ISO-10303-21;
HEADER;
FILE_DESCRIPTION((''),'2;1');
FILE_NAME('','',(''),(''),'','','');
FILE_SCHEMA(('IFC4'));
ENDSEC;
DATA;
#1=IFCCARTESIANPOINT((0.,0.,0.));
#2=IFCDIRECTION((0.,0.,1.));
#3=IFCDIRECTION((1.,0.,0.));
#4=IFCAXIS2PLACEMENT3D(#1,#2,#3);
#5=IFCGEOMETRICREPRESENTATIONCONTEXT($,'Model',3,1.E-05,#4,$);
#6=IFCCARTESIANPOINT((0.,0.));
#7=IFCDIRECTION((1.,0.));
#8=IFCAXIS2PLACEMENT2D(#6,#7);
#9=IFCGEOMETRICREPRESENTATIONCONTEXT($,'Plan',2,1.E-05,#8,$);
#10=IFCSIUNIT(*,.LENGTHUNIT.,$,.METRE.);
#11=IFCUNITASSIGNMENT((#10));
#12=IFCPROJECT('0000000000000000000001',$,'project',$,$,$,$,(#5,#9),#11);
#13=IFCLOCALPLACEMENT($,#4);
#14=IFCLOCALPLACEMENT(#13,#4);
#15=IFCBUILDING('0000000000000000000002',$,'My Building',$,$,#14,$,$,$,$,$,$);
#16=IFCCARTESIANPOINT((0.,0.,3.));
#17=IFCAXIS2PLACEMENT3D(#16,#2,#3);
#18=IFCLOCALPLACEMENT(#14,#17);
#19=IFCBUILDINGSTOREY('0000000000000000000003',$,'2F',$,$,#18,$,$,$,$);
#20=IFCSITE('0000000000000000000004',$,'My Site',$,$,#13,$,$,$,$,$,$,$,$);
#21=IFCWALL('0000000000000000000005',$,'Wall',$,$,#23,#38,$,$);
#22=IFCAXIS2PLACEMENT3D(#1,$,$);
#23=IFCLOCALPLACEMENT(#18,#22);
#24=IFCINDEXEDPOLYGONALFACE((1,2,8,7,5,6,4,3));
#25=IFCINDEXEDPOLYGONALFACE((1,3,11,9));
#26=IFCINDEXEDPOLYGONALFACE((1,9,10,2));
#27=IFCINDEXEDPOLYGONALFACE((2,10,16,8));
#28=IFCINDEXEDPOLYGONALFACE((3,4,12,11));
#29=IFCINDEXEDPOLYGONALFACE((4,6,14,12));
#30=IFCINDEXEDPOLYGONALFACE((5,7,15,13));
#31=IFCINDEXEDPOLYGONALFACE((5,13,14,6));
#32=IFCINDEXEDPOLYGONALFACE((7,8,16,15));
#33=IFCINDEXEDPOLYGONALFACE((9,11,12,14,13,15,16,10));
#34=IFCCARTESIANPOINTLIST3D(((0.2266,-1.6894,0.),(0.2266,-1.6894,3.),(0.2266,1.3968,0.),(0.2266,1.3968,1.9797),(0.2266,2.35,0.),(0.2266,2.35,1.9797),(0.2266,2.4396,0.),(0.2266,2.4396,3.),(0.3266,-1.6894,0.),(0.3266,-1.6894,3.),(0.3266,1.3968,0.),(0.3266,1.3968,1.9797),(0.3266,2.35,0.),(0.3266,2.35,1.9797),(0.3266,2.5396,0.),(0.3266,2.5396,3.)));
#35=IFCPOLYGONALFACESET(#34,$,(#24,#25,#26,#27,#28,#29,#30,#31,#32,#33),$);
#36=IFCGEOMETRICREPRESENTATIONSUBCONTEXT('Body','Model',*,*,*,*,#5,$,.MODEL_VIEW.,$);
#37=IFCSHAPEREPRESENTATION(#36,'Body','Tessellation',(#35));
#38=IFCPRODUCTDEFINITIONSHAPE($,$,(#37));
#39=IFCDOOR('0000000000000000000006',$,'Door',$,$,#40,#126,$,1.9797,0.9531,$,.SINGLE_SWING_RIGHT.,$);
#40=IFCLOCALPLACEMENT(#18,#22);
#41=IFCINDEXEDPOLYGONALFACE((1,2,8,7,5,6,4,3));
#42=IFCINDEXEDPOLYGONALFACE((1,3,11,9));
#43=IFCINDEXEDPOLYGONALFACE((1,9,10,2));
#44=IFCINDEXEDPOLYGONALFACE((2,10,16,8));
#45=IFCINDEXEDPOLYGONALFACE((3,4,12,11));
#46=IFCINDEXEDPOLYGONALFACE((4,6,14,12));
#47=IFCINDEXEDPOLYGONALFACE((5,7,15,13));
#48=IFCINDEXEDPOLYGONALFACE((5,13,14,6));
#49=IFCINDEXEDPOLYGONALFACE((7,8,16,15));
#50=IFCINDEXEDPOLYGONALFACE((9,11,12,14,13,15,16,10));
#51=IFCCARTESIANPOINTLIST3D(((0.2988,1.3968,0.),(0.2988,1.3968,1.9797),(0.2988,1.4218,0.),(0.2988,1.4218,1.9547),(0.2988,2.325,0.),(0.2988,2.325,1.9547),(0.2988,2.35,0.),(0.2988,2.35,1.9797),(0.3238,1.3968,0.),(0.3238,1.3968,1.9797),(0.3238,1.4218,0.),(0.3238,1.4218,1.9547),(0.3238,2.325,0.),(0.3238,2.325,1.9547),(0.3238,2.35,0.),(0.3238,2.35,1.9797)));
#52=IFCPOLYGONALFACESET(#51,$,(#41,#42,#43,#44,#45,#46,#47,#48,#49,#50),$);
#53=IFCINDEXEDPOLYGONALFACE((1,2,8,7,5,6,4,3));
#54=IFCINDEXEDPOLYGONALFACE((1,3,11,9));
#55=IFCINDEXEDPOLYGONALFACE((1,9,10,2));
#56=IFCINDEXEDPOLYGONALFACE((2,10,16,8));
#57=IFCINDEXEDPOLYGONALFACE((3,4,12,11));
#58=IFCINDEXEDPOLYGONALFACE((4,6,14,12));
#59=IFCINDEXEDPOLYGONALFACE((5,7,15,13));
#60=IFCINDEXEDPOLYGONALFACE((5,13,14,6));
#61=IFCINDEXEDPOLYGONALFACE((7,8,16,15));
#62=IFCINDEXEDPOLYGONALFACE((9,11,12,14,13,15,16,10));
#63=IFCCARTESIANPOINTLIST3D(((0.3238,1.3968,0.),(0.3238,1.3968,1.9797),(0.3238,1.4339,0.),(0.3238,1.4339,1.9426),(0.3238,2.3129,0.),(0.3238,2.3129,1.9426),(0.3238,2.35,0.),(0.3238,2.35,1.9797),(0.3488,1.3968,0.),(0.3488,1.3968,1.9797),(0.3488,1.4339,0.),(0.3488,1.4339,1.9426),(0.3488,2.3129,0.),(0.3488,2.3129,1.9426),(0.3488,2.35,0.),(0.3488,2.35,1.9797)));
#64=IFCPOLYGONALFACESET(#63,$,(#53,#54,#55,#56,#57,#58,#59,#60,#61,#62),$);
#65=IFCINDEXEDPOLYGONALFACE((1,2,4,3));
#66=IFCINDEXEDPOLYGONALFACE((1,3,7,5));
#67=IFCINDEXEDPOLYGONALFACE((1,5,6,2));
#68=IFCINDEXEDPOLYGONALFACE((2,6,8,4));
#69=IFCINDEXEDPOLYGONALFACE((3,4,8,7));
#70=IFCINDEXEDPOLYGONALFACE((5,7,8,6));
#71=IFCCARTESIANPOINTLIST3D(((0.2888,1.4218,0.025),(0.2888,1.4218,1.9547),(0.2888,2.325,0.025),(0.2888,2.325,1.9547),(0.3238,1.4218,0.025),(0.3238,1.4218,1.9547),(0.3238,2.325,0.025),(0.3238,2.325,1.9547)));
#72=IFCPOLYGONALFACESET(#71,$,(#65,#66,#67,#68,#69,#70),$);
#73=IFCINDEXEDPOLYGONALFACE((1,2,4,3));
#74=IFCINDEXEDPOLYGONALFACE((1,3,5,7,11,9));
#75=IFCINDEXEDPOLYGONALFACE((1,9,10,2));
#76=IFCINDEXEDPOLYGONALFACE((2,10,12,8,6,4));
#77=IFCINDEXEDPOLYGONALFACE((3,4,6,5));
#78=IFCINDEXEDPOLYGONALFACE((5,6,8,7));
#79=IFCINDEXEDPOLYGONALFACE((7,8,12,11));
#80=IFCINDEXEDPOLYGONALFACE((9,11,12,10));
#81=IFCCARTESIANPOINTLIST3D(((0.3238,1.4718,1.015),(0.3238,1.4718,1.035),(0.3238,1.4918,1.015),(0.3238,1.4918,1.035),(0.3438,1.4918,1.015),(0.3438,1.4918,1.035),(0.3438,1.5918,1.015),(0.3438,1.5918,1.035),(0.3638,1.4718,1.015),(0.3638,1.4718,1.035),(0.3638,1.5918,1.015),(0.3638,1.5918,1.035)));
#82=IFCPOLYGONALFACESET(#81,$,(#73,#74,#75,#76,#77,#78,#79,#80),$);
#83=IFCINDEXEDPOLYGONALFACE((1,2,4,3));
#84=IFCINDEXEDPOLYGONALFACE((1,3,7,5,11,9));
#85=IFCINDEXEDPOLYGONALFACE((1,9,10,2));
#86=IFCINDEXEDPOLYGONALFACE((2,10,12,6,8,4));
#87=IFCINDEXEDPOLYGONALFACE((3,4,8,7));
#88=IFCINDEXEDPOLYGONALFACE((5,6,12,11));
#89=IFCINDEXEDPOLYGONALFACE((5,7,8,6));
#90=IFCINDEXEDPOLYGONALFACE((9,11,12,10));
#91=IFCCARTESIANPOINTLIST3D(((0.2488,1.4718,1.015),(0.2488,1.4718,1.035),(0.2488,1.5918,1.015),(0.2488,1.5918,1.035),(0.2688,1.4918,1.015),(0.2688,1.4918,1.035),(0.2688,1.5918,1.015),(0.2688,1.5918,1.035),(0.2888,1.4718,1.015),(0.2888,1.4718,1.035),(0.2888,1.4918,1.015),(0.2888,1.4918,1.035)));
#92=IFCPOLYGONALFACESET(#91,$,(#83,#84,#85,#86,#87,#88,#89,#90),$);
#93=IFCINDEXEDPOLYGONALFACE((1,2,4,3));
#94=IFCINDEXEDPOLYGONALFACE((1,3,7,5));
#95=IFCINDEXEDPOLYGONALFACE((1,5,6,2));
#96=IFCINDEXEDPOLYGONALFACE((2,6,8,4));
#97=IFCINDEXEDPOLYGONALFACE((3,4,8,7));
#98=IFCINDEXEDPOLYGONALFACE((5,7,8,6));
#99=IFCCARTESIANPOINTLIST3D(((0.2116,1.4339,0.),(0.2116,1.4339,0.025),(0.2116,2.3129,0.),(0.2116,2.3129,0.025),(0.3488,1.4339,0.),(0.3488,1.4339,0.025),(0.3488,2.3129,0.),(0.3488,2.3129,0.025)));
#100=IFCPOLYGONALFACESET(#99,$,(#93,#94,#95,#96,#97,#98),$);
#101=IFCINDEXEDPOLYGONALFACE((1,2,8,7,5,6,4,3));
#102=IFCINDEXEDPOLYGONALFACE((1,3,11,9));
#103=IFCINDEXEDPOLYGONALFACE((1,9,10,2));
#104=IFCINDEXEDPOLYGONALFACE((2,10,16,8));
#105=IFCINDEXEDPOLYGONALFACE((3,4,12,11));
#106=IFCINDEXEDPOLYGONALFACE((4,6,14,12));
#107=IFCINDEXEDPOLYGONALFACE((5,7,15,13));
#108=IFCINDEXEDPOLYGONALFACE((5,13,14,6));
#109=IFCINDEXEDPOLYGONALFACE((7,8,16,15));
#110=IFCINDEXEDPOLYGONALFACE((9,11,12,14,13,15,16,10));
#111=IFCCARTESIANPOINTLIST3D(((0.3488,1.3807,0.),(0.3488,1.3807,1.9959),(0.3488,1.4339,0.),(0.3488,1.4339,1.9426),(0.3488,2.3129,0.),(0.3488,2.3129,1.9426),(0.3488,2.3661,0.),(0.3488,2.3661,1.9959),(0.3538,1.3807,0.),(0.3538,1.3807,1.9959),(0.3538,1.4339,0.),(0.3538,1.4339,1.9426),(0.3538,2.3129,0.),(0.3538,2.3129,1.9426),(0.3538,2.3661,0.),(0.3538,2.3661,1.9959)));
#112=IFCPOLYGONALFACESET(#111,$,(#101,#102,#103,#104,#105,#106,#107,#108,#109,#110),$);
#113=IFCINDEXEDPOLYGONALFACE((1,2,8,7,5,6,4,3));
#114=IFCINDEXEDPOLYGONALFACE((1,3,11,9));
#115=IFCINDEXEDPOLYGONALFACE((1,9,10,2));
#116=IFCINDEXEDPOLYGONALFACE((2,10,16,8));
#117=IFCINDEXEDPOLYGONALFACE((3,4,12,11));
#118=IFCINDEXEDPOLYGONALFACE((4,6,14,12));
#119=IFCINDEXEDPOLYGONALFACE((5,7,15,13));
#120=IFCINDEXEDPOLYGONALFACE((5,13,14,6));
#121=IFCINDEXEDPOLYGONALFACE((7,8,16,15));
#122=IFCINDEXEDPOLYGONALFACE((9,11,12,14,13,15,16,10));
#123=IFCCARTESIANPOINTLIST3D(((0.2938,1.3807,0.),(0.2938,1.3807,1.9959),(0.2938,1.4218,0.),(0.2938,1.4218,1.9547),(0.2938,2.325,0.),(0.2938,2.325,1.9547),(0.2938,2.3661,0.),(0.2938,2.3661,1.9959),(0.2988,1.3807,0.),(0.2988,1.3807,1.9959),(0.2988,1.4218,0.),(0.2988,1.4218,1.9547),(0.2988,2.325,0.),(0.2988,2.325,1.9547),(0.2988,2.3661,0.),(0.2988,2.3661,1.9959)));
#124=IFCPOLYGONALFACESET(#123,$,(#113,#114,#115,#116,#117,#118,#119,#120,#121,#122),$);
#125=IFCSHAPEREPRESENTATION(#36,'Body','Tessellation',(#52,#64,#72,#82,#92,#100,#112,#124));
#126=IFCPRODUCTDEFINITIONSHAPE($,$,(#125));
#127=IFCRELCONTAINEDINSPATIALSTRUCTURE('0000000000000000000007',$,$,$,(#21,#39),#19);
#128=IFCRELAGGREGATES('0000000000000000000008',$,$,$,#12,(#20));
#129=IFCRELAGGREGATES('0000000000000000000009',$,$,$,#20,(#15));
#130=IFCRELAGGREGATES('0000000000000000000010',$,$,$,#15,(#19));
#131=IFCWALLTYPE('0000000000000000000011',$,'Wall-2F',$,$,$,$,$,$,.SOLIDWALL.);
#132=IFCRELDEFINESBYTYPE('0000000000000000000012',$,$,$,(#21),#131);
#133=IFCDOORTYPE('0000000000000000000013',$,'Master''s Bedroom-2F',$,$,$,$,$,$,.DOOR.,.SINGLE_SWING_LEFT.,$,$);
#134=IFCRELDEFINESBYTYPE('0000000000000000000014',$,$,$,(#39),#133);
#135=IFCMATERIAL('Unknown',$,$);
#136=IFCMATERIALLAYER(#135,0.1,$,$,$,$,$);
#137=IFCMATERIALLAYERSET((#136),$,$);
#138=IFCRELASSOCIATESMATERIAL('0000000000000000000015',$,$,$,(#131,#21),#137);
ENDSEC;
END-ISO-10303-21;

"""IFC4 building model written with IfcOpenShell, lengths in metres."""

from ifc_helpers import new_model, entity, si_unit, frame, origin_with_axes, origin_2d_with_axis, place, context, subcontext, project, spatial, line, indexed_curve, outline, extrude, shape, source, transform, mapped, material, layer, layer_set, layer_usage, type_object, type_shapes, element, fill, save


model = new_model("IFC4")

# Units and contexts
model_context = context("Model", 3, precision=1e-05, world=origin_with_axes())
plan_context = context("Plan", 2, precision=1e-05, world=origin_2d_with_axis())
body_context_1 = subcontext(model_context, "Body", "Model", "MODEL_VIEW")
body_context_2 = subcontext(plan_context, "Body", "Plan", "PLAN_VIEW")
ifc_project = project(units=[si_unit("LENGTHUNIT", "METRE")], contexts=[model_context, plan_context])

# Site, building, storey
site_placement = place(None, origin_with_axes())
site = spatial("IfcSite", under=ifc_project, at=site_placement, Name="My Site")
building_placement = place(site_placement, origin_with_axes())
building = spatial("IfcBuilding", under=site, at=building_placement, Name="My Building")
storey_placement = place(building_placement, frame((0.0, 0.0, 3.0), z_axis=(0.0, 0.0, 1.0), x_axis=(1.0, 0.0, 0.0)))
storey = spatial("IfcBuildingStorey", under=building, at=storey_placement, Name="2F")

# Shared definitions
ifc_material = material(Name="Unknown")

# Shared definitions
ifc_layer_1 = layer(ifc_material, 0.1)
ifc_layer_set_1 = layer_set([ifc_layer_1])
wall_type = type_object("IfcWallType", Name="Wall-2F", PredefinedType="SOLIDWALL", material=ifc_layer_set_1)

# Wall, opening, door
ifc_layer_usage_1 = layer_usage(ifc_layer_set_1, "AXIS2", "POSITIVE", 0.0)
wall_1_placement = place(storey_placement, frame((0.3266, -1.6894, 0.0), z_axis=(0.0, 0.0, 1.0), x_axis=(0.0, 1.0, 0.0)))
wall_1 = element("IfcWall", 1, at=wall_1_placement, inside=storey, type_object=wall_type, material=ifc_layer_usage_1, Name="Wall", context=body_context_1, shape_type="SweptSolid", body=[
    extrude(outline(indexed_curve([(0.0, 0.0), (0.0, 0.1), (4.129, 0.1), (4.229, 0.0)], segments=[line(1, 2, 3, 4, 1)])), origin_with_axes(), (0.0, 0.0, 1.0), 3.0),
])
shared_shape_1 = source(origin_with_axes(), body_context_1, "Body", "SweptSolid", [
    extrude(outline(indexed_curve([(0.0, 0.0), (0.9531, 0.0), (0.9531, 1.9797), (0.0, 1.9797)], segments=[line(1, 2, 3, 4, 1)])), frame((0.0, -0.6, 0.0), z_axis=(0.0, -1.0, 0.0), x_axis=(1.0, 0.0, 0.0)), (0.0, 0.0, -1.0), 1.2),
])
opening_1_placement = place(wall_1_placement, frame((3.0862, -0.0222, 0.0), z_axis=(0.0, 0.0, 1.0), x_axis=(1.0, 0.0, 0.0)))
opening_1 = element("IfcOpeningElement", 2, at=opening_1_placement, cuts=wall_1, PredefinedType="OPENING", context=body_context_1, shape_type="MappedRepresentation", body=[
    mapped(shared_shape_1, transform((0.0, 0.0, 0.0), x_axis=(1.0, 0.0, 0.0), y_axis=(0.0, 1.0, 0.0), z_axis=(0.0, 0.0, 1.0), scale=1.0)),
])
door_type_1 = type_object("IfcDoorType", Name="Master's Bedroom-2F", OperationType="SINGLE_SWING_LEFT", PredefinedType="DOOR")
shared_shape_2 = source(origin_with_axes(), body_context_1, "Body", "SweptSolid", [
    extrude(outline(indexed_curve([(0.0, 0.0), (0.0, 1.9797), (0.9531, 1.9797), (0.9531, 0.0), (0.9281, 0.0), (0.9281, 1.9547), (0.025, 1.9547), (0.025, 0.0)], segments=[line(1, 2, 3, 4, 5, 6, 7, 8, 1)])), frame((0.0, 0.025, 0.0), z_axis=(0.0, -1.0, 0.0), x_axis=(1.0, 0.0, 0.0)), (0.0, 0.0, -1.0), 0.025),
    extrude(outline(indexed_curve([(0.0, 0.0), (0.0, 1.9797), (0.9531, 1.9797), (0.9531, 0.0), (0.9161, 0.0), (0.9161, 1.9426), (0.0371, 1.9426), (0.0371, 0.0)], segments=[line(1, 2, 3, 4, 5, 6, 7, 8, 1)])), frame((0.0, 0.0, 0.0), z_axis=(0.0, -1.0, 0.0), x_axis=(1.0, 0.0, 0.0)), (0.0, 0.0, -1.0), 0.025),
    extrude(outline(indexed_curve([(0.0, 0.0), (0.9031, 0.0), (0.9031, 0.035), (0.0, 0.035)], segments=[line(1, 2, 3, 4, 1)])), frame((0.025, 0.025, 0.025), z_axis=(0.0, 0.0, 1.0), x_axis=(1.0, 0.0, 0.0)), (0.0, 0.0, 1.0), 1.9297),
    extrude(outline(indexed_curve([(0.0, 0.0), (0.0, -0.04), (0.12, -0.04), (0.12, -0.02), (0.02, -0.02), (0.02, 0.0)], segments=[line(1, 2, 3, 4, 5, 6, 1)])), frame((0.075, 0.025, 1.015), z_axis=(0.0, 0.0, 1.0), x_axis=(1.0, 0.0, 0.0)), (0.0, 0.0, 1.0), 0.02),
    extrude(outline(indexed_curve([(0.0, 0.0), (0.0, 0.04), (0.12, 0.04), (0.12, 0.02), (0.02, 0.02), (0.02, 0.0)], segments=[line(1, 2, 3, 4, 5, 6, 1)])), frame((0.075, 0.06, 1.015), z_axis=(0.0, 0.0, 1.0), x_axis=(1.0, 0.0, 0.0)), (0.0, 0.0, 1.0), 0.02),
    extrude(outline(indexed_curve([(0.0, 0.0), (0.879, 0.0), (0.879, 0.1372), (0.0, 0.1372)], segments=[line(1, 2, 3, 4, 1)])), frame((0.0371, 0.0, 0.0), z_axis=(0.0, 0.0, 1.0), x_axis=(1.0, 0.0, 0.0)), (0.0, 0.0, 1.0), 0.025),
    extrude(outline(indexed_curve([(0.0, 0.0), (0.0, 1.9959), (0.9855, 1.9959), (0.9855, 0.0), (0.9322, 0.0), (0.9322, 1.9426), (0.0532, 1.9426), (0.0532, 0.0)], segments=[line(1, 2, 3, 4, 5, 6, 7, 8, 1)])), frame((-0.0162, -0.005, 0.0), z_axis=(0.0, -1.0, 0.0), x_axis=(1.0, 0.0, 0.0)), (0.0, 0.0, -1.0), 0.005),
    extrude(outline(indexed_curve([(0.0, 0.0), (0.0, 1.9959), (0.9855, 1.9959), (0.9855, 0.0), (0.9443, 0.0), (0.9443, 1.9547), (0.0412, 1.9547), (0.0412, 0.0)], segments=[line(1, 2, 3, 4, 5, 6, 7, 8, 1)])), frame((-0.0162, 0.05, 0.0), z_axis=(0.0, -1.0, 0.0), x_axis=(1.0, 0.0, 0.0)), (0.0, 0.0, -1.0), 0.005),
])
shared_shape_3 = source(origin_with_axes(), body_context_2, "Body", "Curve2D", [
    entity("IfcIndexedPolyCurve", entity("IfcCartesianPointList2D", [[0.0, 0.0], [0.0, 0.05], [0.025, 0.05], [0.025, 0.025], [0.0371, 0.025], [0.0371, 0.0]]), [entity("IfcLineIndex", [1, 2, 3, 4, 5, 6, 1])]),
    entity("IfcIndexedPolyCurve", entity("IfcCartesianPointList2D", [[0.9531, 0.0], [0.9531, 0.05], [0.9281, 0.05], [0.9281, 0.025], [0.9161, 0.025], [0.9161, 0.0]]), [entity("IfcLineIndex", [1, 2, 3, 4, 5, 6, 1])]),
    entity("IfcTrimmedCurve", entity("IfcEllipse", entity("IfcAxis2Placement2D", entity("IfcCartesianPoint", [0.8931, 0.05]), entity("IfcDirection", [1.0, 0.0])), 0.8681, 0.9031), [entity("IfcCartesianPoint", [0.8931, 0.9531])], [entity("IfcCartesianPoint", [0.025, 0.05])], True, "CARTESIAN"),
    entity("IfcIndexedPolyCurve", entity("IfcCartesianPointList2D", [[0.9281, 0.05], [0.8931, 0.05], [0.8931, 0.9531], [0.9281, 0.9531]]), [entity("IfcLineIndex", [1, 2, 3, 4, 1])]),
])
type_shapes(door_type_1, [shared_shape_2, shared_shape_3])
door_1_placement = place(opening_1_placement, frame((0.0, 0.0, 0.0), z_axis=(0.0, 0.0, 1.0), x_axis=(1.0, 0.0, 0.0)))
door_1 = element("IfcDoor", 3, at=door_1_placement, inside=storey, type_object=door_type_1, Name="Door", OperationType="SINGLE_SWING_RIGHT", OverallHeight=1.9797, OverallWidth=0.9531, shapes=[
    shape(body_context_1, "Body", "MappedRepresentation", [mapped(shared_shape_2, transform((0.0, 0.0, 0.0), x_axis=(1.0, 0.0, 0.0), y_axis=(0.0, 1.0, 0.0), z_axis=(0.0, 0.0, 1.0), scale=1.0))]),
    shape(body_context_2, "Body", "MappedRepresentation", [mapped(shared_shape_3, transform((0.0, 0.0, 0.0), x_axis=(1.0, 0.0, 0.0), y_axis=(0.0, 1.0, 0.0), z_axis=(0.0, 0.0, 1.0), scale=1.0))]),
])
fill(opening_1, door_1)

save(model, "model.ifc")
